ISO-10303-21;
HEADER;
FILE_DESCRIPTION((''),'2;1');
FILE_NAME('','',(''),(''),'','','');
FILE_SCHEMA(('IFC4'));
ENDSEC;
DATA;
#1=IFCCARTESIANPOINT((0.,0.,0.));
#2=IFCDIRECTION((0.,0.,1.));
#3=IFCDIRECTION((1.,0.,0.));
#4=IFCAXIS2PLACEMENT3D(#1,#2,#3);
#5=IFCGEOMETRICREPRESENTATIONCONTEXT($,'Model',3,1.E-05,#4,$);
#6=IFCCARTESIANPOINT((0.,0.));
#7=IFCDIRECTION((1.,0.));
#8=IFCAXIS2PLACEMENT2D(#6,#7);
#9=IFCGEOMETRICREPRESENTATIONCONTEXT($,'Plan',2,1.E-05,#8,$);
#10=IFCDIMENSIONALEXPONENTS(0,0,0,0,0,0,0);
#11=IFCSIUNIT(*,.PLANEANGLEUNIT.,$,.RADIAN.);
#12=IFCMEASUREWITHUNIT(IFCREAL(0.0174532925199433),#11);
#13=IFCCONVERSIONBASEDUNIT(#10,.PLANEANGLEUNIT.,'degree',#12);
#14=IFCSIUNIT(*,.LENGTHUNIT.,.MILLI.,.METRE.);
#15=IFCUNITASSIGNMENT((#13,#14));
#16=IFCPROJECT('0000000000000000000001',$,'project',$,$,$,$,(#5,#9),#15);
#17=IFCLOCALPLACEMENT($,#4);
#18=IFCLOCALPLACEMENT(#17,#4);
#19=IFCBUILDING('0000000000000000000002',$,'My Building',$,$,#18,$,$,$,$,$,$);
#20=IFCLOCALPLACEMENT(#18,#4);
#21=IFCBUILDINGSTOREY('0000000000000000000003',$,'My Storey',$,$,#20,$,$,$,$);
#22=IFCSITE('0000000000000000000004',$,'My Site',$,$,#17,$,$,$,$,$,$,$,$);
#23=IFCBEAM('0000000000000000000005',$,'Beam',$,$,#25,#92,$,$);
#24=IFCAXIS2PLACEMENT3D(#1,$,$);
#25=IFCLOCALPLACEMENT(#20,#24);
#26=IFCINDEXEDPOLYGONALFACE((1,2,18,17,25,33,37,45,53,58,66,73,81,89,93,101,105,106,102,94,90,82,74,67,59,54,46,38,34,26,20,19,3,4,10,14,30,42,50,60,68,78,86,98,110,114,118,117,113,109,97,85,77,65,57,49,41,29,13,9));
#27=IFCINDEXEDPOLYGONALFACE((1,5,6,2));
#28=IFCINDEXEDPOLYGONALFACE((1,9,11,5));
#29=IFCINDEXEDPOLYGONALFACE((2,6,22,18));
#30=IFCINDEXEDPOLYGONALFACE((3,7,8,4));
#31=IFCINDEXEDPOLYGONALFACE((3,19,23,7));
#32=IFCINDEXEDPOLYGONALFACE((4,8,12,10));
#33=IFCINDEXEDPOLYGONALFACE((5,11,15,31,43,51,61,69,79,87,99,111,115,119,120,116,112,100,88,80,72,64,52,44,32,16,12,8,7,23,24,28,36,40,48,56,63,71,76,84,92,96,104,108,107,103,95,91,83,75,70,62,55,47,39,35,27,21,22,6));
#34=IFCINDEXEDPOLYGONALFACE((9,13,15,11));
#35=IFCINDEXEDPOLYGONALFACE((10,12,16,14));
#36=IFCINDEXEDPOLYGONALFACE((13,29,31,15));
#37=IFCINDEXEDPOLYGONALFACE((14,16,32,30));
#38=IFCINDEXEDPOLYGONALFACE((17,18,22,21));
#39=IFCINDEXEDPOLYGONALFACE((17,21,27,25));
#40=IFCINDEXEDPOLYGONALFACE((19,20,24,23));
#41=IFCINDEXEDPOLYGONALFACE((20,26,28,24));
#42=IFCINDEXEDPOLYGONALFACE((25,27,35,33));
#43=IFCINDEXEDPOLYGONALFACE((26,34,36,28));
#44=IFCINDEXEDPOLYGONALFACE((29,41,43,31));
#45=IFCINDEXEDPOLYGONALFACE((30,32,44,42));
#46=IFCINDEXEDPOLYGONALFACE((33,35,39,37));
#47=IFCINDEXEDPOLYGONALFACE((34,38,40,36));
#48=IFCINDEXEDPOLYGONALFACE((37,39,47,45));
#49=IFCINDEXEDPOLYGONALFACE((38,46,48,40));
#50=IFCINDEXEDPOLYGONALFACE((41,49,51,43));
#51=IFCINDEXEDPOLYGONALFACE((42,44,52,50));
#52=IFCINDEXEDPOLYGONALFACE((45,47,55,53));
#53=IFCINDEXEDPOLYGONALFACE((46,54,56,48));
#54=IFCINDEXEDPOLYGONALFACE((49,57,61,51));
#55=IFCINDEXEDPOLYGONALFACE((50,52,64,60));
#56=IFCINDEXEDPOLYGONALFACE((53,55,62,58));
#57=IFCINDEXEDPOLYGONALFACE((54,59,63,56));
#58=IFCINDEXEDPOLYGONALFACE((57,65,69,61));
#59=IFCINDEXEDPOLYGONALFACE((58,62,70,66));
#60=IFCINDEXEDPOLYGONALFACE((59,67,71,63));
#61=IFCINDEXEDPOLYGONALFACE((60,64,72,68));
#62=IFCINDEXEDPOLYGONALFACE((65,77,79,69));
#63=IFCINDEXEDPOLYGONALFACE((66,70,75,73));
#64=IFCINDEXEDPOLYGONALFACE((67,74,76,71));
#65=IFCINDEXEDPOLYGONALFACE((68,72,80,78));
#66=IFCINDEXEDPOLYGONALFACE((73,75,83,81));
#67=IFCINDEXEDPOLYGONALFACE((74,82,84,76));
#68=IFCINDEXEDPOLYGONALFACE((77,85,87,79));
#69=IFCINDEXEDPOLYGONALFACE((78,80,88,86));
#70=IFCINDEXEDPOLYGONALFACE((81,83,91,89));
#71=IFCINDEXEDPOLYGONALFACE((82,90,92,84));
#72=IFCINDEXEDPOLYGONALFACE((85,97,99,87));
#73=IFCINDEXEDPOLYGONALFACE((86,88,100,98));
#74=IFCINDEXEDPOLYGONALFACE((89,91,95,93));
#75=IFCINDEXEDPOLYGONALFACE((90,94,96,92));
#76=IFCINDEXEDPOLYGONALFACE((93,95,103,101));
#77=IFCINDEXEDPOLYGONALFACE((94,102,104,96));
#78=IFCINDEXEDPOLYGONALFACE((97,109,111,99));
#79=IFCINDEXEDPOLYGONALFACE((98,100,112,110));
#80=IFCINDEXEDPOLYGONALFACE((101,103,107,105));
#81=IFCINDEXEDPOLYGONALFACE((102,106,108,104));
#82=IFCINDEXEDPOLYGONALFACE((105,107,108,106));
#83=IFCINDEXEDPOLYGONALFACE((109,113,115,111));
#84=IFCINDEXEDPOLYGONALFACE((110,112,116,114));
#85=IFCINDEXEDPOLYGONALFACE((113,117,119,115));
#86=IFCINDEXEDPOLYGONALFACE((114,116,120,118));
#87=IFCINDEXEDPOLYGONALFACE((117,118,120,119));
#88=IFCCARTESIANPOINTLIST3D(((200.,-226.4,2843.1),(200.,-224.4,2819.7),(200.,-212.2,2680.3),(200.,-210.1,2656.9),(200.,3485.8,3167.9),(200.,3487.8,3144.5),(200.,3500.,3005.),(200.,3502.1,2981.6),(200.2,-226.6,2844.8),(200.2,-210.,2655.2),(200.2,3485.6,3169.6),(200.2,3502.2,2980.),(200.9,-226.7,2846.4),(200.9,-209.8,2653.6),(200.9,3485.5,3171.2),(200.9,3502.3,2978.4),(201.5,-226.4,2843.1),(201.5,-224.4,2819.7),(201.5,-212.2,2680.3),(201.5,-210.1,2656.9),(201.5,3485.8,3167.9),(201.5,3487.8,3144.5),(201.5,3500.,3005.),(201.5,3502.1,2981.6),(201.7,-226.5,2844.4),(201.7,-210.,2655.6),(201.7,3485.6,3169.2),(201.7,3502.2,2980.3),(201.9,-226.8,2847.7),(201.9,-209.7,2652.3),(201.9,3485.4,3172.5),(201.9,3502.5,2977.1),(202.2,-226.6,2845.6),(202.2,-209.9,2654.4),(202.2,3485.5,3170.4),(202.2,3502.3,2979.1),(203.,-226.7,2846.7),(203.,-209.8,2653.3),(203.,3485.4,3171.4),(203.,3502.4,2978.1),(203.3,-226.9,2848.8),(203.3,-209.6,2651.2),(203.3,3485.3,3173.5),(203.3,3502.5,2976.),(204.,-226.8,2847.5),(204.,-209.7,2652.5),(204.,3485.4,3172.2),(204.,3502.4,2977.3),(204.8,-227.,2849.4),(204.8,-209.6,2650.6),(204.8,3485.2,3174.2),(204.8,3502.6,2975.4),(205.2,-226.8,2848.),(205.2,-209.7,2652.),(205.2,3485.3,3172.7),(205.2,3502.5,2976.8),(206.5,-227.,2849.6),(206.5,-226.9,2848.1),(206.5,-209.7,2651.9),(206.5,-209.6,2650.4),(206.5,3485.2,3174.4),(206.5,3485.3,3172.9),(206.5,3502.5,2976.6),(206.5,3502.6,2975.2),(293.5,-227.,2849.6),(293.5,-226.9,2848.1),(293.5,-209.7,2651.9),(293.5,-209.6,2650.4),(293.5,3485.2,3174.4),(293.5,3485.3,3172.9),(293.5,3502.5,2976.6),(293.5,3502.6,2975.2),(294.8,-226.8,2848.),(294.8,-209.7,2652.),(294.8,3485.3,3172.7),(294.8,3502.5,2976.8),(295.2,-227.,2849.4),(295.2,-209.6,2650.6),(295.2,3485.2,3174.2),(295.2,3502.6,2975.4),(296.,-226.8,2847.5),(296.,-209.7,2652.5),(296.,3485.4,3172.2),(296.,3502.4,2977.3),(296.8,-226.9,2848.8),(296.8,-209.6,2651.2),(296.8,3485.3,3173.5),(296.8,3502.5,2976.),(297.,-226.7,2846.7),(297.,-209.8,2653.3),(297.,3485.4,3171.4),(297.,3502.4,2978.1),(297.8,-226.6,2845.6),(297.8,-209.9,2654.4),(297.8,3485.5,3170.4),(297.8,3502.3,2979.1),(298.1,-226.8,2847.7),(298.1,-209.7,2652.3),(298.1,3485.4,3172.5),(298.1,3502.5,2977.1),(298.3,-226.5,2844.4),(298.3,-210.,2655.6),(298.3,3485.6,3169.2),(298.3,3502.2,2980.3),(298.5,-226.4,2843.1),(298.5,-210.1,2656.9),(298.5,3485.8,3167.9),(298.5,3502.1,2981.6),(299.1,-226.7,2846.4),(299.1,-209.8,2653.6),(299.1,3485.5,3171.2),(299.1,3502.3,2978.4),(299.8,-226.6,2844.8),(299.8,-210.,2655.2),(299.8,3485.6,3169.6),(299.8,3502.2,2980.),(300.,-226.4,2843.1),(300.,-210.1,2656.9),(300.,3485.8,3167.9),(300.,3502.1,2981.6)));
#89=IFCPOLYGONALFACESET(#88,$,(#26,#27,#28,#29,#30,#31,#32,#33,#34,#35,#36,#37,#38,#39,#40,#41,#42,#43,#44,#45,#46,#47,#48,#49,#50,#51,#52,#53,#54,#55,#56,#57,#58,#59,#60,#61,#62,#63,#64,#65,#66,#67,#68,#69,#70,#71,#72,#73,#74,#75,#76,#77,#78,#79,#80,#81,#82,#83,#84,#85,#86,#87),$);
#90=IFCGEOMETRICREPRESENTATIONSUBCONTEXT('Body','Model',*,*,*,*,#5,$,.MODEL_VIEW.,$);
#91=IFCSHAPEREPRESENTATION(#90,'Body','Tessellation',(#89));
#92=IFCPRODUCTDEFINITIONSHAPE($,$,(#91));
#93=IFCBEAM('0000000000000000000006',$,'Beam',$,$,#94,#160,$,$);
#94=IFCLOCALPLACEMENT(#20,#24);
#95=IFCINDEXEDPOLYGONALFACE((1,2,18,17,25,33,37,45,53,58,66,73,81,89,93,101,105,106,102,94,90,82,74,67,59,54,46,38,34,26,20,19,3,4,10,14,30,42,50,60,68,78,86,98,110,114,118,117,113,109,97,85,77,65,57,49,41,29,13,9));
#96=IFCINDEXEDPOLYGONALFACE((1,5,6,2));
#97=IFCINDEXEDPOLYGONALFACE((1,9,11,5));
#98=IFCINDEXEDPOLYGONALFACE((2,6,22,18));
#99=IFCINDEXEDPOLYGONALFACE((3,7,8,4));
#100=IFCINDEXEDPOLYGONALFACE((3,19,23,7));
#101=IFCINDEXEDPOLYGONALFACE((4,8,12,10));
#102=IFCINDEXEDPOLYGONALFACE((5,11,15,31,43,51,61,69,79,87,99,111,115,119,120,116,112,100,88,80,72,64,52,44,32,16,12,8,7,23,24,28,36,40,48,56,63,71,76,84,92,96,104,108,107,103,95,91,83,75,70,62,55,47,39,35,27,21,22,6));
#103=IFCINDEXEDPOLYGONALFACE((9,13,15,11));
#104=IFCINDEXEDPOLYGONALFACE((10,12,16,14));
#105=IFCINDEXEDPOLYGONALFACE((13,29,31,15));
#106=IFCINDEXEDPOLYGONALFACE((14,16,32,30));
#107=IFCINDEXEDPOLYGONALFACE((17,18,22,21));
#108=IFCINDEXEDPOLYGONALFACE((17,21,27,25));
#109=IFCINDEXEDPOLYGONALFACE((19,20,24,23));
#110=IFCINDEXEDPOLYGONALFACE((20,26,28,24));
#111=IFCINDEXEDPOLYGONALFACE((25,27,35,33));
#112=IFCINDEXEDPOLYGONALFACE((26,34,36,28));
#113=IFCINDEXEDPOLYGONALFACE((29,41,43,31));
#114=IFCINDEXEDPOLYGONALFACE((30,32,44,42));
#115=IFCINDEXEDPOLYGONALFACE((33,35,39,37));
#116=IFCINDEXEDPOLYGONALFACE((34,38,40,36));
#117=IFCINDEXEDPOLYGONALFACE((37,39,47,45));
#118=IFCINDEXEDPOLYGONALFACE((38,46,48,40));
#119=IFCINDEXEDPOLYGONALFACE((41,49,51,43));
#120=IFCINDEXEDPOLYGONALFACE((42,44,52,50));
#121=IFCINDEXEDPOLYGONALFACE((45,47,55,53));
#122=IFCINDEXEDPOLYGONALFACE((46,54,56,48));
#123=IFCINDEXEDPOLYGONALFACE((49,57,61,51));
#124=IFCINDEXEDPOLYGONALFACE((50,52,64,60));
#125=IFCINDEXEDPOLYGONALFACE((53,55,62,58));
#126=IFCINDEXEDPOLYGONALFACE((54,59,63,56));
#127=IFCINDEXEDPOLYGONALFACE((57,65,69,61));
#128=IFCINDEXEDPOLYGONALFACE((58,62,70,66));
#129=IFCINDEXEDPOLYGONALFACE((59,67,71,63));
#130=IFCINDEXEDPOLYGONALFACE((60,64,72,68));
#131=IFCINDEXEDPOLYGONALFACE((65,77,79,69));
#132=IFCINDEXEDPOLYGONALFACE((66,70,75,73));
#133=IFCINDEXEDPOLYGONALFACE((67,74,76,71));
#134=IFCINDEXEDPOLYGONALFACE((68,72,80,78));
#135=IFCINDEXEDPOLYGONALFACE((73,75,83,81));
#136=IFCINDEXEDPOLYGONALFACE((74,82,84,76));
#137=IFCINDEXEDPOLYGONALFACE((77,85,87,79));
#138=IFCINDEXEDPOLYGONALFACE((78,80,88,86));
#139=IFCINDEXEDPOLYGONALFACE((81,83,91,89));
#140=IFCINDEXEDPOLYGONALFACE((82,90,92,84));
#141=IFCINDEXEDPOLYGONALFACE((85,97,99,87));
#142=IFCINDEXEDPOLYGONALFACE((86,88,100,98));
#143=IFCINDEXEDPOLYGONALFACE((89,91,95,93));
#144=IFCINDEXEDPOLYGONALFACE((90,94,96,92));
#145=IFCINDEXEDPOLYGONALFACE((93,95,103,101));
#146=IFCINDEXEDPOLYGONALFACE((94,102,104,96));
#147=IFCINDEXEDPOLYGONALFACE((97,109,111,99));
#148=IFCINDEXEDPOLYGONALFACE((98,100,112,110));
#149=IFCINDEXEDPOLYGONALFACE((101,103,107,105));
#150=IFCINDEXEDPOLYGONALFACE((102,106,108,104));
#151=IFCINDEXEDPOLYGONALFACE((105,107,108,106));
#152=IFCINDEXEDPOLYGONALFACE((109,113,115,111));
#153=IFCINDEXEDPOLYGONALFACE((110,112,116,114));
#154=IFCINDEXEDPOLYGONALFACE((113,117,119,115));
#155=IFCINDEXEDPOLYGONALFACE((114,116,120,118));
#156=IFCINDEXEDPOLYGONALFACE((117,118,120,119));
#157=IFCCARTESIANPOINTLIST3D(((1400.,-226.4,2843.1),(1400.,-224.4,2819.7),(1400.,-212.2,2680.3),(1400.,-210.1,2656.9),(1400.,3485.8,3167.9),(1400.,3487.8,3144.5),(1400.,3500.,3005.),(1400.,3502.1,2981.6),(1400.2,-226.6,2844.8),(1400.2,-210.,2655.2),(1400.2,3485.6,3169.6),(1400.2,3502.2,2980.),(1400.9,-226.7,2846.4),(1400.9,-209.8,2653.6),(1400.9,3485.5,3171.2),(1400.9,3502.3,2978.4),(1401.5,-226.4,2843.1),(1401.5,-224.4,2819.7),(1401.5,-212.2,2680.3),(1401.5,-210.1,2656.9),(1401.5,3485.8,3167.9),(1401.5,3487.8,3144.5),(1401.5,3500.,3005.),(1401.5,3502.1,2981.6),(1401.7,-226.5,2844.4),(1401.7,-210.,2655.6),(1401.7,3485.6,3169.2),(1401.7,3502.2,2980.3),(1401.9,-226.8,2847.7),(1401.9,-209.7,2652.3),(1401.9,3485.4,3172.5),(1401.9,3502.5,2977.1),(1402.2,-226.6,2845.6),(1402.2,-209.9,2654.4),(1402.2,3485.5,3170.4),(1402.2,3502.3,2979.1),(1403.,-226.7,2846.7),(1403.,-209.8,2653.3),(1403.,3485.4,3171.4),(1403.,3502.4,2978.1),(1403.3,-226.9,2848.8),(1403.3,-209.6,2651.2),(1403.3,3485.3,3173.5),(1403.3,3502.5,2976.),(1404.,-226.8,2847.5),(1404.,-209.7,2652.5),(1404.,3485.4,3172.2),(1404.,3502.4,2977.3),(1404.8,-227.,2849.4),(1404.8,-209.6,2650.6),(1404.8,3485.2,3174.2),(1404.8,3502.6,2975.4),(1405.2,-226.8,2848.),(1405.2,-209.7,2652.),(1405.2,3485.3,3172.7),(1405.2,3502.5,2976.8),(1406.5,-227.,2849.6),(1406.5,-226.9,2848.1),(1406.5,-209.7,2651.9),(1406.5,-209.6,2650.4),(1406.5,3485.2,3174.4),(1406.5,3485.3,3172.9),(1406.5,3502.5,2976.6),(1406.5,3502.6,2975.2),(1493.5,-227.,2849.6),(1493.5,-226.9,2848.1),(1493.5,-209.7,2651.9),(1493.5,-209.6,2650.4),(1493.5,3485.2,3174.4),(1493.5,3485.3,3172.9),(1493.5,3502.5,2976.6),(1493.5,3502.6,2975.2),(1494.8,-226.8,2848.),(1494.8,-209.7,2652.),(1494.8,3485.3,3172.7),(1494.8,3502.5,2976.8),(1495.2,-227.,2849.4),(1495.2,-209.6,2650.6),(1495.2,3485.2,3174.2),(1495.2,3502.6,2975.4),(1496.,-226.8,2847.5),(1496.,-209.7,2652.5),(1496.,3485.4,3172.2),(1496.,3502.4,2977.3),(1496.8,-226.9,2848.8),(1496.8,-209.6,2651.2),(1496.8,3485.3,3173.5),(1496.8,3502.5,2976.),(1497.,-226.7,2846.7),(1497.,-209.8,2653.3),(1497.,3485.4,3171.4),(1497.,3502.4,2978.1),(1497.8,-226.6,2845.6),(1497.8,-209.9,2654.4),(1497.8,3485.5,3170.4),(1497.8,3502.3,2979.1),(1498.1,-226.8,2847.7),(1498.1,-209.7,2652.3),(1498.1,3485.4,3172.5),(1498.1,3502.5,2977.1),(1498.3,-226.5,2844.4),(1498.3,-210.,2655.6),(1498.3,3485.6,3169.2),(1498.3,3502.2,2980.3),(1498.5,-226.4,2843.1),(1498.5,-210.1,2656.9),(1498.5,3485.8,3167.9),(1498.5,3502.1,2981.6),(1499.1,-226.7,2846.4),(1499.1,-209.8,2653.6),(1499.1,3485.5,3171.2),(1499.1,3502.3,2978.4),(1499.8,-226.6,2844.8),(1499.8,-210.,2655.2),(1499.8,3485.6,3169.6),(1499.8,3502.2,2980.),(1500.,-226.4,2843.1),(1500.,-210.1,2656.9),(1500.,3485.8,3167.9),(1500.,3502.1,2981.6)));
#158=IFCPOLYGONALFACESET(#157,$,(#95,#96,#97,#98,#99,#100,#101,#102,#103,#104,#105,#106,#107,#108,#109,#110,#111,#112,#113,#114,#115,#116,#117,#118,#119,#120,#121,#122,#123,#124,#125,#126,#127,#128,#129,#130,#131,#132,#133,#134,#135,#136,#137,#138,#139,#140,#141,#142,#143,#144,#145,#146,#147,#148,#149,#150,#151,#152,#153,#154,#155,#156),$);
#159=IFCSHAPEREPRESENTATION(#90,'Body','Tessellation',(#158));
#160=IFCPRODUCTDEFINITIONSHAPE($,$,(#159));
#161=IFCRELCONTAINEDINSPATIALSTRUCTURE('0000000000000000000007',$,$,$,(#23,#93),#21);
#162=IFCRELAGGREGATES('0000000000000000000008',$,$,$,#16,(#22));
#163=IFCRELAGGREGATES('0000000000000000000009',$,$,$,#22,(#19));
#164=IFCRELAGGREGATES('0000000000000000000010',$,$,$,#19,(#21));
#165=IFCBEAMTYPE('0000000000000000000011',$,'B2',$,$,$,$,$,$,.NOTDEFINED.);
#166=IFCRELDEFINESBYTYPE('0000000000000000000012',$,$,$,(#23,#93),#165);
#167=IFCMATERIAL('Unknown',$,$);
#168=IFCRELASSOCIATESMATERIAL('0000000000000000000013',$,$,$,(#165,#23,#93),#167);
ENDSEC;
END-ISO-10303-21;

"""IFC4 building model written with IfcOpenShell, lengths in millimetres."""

from ifc_helpers import new_model, entity, si_unit, converted_unit, frame, origin_with_axes, origin_2d_with_axis, place, context, subcontext, project, spatial, c_section, extrude, material, material_profile, profile_set, profile_usage, type_object, element, save


model = new_model("IFC4")

# Units and contexts
model_context = context("Model", 3, precision=1e-05, world=origin_with_axes())
plan_context = context("Plan", 2, precision=1e-05, world=origin_2d_with_axis())
body_context = subcontext(model_context, "Body", "Model", "MODEL_VIEW")
ifc_project = project(units=[converted_unit("PLANEANGLEUNIT", "degree", entity("IfcReal", 0.0174532925199433), si_unit("PLANEANGLEUNIT", "RADIAN"), dimensions=[0, 0, 0, 0, 0, 0, 0]), si_unit("LENGTHUNIT", "METRE", prefix="MILLI")], contexts=[model_context, plan_context])

# Site, building, storey
site_placement = place(None, origin_with_axes())
site = spatial("IfcSite", under=ifc_project, at=site_placement, Name="My Site")
building_placement = place(site_placement, origin_with_axes())
building = spatial("IfcBuilding", under=site, at=building_placement, Name="My Building")
storey_placement = place(building_placement, origin_with_axes())
storey = spatial("IfcBuildingStorey", under=building, at=storey_placement, Name="My Storey")

# Shared definitions
ifc_material = material(Name="Unknown")

# Beams
ifc_material_profile_1 = material_profile(ifc_material, c_section(Depth=200.0, Width=100.0, WallThickness=1.5, Girth=30.0, InternalFilletRadius=5.0))
ifc_profile_set_1 = profile_set([ifc_material_profile_1])
ifc_profile_usage_1 = profile_usage(ifc_profile_set_1, cardinal=5)
beam_type_1 = type_object("IfcBeamType", Name="B2", PredefinedType="NOTDEFINED", material=ifc_profile_set_1)
beam_1_placement = place(storey_placement, frame((250.0, -218.3, 2750.0), z_axis=(0.0, 0.996195, 0.087156), x_axis=(-1.0, 0.0, 0.0)))
element("IfcBeam", 1, at=beam_1_placement, inside=storey, type_object=beam_type_1, material=ifc_profile_usage_1, Name="Beam", context=body_context, shape_type="SweptSolid", body=[
    extrude(c_section(Depth=200.0, Width=100.0, WallThickness=1.5, Girth=30.0, InternalFilletRadius=5.0), origin_with_axes(), (0.0, 0.0, 1.0), 3726.4),
])
ifc_profile_usage_2 = profile_usage(ifc_profile_set_1, cardinal=5)
beam_2_placement = place(storey_placement, frame((1450.0, -218.3, 2750.0), z_axis=(0.0, 0.996195, 0.087156), x_axis=(-1.0, 0.0, 0.0)))
element("IfcBeam", 2, at=beam_2_placement, inside=storey, type_object=beam_type_1, material=ifc_profile_usage_2, Name="Beam", context=body_context, shape_type="SweptSolid", body=[
    extrude(c_section(Depth=200.0, Width=100.0, WallThickness=1.5, Girth=30.0, InternalFilletRadius=5.0), origin_with_axes(), (0.0, 0.0, 1.0), 3726.4),
])

save(model, "model.ifc")
